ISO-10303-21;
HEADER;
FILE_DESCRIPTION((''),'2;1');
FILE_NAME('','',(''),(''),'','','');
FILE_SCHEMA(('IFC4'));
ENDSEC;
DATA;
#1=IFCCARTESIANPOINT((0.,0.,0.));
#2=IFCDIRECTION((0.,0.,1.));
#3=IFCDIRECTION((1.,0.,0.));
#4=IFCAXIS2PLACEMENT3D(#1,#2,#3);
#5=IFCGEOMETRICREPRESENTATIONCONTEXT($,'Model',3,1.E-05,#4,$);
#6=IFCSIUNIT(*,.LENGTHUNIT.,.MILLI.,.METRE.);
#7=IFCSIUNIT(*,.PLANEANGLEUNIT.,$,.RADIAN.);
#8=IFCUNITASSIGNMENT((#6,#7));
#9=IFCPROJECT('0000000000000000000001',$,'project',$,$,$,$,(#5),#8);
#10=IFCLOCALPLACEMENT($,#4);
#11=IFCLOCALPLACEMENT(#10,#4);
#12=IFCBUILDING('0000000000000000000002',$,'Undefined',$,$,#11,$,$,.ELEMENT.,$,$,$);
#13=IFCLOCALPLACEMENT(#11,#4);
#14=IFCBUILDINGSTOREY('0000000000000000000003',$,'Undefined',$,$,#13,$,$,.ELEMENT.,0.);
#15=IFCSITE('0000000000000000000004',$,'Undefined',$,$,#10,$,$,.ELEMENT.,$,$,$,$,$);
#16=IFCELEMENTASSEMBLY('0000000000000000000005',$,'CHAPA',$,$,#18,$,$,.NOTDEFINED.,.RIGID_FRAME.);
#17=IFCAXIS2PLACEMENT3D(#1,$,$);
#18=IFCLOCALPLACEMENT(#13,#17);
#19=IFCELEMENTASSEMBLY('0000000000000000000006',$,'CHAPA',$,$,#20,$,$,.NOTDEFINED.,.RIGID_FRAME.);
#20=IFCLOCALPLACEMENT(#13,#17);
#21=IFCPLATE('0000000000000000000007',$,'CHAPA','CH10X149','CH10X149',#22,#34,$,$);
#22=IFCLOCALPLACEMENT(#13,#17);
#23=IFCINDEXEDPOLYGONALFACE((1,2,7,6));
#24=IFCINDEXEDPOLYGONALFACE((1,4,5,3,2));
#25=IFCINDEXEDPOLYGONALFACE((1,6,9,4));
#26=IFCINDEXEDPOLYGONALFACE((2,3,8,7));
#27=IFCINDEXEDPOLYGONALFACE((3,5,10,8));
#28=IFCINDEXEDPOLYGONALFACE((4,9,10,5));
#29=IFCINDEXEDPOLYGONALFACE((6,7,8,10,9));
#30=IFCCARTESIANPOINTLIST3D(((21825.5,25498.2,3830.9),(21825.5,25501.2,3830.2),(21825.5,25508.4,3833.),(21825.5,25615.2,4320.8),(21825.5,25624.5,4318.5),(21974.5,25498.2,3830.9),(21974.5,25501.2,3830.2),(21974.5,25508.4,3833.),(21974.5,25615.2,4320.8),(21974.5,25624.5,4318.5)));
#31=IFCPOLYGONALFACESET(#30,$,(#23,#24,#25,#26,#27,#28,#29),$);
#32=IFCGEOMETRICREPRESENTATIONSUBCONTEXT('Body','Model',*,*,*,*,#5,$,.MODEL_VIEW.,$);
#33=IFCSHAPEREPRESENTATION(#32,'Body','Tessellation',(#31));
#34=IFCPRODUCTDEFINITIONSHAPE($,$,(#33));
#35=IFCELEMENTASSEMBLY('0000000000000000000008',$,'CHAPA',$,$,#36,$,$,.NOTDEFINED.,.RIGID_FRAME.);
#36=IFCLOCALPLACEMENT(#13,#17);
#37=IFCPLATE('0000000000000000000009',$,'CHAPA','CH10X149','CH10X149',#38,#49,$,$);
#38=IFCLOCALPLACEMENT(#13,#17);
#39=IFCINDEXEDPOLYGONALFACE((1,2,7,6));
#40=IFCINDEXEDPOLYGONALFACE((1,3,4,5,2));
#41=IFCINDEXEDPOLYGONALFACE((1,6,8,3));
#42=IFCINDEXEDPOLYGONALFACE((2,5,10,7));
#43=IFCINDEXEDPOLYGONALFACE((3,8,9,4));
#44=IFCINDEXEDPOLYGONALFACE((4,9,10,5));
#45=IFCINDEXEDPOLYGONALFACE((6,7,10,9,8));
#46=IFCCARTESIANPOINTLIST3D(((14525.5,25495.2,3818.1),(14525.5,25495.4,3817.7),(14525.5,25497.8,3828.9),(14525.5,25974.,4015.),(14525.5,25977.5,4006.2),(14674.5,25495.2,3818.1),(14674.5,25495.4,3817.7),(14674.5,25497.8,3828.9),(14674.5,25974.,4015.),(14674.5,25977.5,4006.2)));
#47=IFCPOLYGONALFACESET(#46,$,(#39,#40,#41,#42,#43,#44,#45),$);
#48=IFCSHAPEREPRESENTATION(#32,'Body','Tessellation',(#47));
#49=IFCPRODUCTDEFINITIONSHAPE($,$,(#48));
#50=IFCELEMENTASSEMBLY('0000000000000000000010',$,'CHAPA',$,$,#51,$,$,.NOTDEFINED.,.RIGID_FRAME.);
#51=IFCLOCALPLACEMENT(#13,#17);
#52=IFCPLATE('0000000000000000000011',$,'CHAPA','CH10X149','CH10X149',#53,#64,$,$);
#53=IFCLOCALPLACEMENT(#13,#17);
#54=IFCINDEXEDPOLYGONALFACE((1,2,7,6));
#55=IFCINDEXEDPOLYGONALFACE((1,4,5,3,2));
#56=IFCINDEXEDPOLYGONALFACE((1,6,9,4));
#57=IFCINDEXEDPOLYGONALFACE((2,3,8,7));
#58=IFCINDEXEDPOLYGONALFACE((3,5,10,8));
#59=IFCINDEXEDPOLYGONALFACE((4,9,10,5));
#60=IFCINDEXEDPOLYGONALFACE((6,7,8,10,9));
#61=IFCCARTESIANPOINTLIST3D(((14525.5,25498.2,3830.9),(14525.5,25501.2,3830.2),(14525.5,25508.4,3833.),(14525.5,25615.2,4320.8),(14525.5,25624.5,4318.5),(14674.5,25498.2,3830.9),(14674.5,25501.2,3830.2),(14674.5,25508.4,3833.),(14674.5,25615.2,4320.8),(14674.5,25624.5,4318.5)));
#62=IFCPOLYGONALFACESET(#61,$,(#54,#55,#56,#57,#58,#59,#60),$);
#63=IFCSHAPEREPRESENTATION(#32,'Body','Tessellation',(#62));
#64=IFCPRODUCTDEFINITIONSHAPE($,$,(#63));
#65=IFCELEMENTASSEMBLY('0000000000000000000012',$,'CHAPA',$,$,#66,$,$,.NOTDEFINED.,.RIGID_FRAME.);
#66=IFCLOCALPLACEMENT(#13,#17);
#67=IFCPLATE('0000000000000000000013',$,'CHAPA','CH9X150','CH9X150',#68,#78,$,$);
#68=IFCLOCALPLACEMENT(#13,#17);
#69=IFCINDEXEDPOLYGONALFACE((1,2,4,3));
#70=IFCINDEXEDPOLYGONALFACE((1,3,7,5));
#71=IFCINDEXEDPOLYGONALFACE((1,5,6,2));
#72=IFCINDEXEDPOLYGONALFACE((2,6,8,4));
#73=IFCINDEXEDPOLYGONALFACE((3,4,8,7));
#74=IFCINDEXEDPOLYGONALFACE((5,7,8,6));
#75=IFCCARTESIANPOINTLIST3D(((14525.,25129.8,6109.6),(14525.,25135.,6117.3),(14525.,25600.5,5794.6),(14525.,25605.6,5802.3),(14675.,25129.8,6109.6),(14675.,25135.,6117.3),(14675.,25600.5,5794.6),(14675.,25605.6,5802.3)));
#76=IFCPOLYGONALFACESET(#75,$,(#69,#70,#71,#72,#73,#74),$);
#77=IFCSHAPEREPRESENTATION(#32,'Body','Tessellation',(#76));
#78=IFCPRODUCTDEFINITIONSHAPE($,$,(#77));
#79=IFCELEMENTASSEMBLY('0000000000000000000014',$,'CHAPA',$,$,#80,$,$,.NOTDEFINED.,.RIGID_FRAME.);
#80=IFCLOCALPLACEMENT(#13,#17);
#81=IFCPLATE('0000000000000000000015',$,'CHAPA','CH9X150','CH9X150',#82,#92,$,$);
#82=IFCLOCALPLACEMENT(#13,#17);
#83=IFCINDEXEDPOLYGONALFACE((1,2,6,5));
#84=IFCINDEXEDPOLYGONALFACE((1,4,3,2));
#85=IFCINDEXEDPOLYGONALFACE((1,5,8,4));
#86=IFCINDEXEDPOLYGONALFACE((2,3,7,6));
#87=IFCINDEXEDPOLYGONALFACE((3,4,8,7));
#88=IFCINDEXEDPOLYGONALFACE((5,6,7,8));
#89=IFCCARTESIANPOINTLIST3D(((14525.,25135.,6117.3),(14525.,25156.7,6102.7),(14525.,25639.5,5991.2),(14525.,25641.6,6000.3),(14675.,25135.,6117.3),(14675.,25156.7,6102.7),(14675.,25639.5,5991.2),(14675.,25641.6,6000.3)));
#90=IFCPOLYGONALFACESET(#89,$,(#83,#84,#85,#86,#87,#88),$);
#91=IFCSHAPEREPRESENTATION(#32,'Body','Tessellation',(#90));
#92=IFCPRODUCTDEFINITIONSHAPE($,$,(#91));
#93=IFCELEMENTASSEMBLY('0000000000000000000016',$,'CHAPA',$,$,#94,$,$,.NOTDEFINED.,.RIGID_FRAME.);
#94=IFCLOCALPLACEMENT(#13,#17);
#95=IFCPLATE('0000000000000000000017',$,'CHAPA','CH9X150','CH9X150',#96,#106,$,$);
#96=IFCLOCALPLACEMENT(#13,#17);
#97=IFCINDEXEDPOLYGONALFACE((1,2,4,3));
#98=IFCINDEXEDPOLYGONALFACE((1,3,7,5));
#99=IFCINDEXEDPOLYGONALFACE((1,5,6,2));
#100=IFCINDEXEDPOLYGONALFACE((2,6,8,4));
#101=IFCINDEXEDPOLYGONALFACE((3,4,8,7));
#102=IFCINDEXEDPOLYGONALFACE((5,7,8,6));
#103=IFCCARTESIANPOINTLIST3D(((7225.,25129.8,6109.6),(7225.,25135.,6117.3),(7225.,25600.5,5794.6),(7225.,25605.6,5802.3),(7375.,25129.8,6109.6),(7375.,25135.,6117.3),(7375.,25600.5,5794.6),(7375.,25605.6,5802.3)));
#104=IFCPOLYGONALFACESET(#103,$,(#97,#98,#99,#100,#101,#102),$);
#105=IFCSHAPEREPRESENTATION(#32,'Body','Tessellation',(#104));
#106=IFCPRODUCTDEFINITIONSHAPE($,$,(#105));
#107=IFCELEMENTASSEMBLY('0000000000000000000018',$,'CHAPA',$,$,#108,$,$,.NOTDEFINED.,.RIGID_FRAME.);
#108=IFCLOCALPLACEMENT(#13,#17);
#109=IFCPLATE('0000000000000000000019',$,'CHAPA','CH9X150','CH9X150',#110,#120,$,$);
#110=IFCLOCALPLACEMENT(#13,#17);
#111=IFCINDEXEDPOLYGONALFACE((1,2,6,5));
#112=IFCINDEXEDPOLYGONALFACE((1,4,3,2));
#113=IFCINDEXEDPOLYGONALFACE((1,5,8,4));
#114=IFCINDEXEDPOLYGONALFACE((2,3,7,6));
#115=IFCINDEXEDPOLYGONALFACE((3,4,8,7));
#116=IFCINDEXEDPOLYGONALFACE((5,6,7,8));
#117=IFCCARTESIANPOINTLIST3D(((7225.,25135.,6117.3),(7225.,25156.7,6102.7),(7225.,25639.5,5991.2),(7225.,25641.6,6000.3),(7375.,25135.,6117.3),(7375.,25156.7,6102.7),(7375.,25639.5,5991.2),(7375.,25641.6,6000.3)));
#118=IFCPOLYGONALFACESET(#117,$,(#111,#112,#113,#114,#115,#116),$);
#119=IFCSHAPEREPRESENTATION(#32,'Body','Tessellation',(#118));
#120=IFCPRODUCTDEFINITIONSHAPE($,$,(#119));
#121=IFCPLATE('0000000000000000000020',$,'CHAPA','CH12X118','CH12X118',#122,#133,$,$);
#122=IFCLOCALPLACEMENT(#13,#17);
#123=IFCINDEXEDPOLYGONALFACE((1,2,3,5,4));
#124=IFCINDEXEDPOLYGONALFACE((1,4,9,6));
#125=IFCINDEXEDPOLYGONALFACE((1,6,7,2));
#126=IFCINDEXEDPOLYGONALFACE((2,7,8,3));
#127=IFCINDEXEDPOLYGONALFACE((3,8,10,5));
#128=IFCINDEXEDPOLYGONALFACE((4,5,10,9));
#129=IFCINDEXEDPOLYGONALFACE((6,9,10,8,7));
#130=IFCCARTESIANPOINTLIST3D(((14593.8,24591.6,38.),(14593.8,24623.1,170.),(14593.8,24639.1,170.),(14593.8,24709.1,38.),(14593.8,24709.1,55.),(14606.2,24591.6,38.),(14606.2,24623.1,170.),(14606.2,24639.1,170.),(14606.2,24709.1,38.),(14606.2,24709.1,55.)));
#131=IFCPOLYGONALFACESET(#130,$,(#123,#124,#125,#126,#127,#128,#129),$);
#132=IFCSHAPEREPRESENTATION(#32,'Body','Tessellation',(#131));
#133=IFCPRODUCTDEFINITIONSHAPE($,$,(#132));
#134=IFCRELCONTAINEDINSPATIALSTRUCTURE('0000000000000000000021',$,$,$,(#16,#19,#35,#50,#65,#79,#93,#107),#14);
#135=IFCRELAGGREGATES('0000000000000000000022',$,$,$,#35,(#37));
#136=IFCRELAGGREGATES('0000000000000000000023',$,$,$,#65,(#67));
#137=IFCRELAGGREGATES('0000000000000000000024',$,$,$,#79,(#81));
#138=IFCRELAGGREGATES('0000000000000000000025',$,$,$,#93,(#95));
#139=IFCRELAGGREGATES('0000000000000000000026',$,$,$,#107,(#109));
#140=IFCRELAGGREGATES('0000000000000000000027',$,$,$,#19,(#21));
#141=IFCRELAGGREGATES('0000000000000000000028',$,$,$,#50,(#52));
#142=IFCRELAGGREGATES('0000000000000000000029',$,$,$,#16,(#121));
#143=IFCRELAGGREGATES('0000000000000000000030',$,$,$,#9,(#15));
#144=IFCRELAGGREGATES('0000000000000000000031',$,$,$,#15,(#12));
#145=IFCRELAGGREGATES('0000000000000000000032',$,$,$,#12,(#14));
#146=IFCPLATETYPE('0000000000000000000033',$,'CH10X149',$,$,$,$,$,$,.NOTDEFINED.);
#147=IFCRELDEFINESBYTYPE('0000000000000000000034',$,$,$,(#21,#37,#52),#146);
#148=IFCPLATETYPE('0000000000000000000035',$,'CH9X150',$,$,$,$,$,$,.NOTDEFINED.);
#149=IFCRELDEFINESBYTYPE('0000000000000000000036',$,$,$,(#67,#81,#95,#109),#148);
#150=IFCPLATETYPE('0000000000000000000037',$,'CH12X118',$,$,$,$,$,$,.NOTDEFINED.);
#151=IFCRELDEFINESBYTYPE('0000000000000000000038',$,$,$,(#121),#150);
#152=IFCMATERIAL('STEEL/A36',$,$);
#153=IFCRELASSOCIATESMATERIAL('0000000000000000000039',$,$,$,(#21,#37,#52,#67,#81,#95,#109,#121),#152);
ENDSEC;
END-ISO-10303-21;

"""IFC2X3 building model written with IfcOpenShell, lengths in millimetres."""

from ifc_helpers import new_model, si_unit, frame, origin_with_axes, place, context, subcontext, project, spatial, polyline, outline, extrude, clip, halfspace, material, type_object, element, aggregate, save


model = new_model("IFC2X3")

# Units and contexts
model_context = context("Model", 3, precision=1e-05, world=origin_with_axes())
body_context = subcontext(model_context, "Body", "Model", "MODEL_VIEW")
ifc_project = project(units=[si_unit("LENGTHUNIT", "METRE", prefix="MILLI"), si_unit("PLANEANGLEUNIT", "RADIAN")], contexts=[model_context])

# Site, building, storey
site_placement = place(None, origin_with_axes())
site = spatial("IfcSite", under=ifc_project, at=site_placement, Name="Undefined", CompositionType="ELEMENT")
building_placement = place(site_placement, origin_with_axes())
building = spatial("IfcBuilding", under=site, at=building_placement, Name="Undefined", CompositionType="ELEMENT")
storey_placement = place(building_placement, origin_with_axes())
storey = spatial("IfcBuildingStorey", under=building, at=storey_placement, Name="Undefined", CompositionType="ELEMENT", Elevation=0.0)

# Element assembly
ifc_material_1 = material(Name="STEEL/A36")
assembly_1_placement = place(storey_placement, origin_with_axes())
assembly_1 = element("IfcElementAssembly", 1, at=assembly_1_placement, inside=storey, Name="CHAPA", AssemblyPlace="NOTDEFINED", PredefinedType="RIGID_FRAME")

# Element assemblies, plates
plate_type_1 = type_object("IfcPlateType", Name="CH10X149", PredefinedType="NOTDEFINED")
assembly_2_placement = place(storey_placement, origin_with_axes())
assembly_2 = element("IfcElementAssembly", 2, at=assembly_2_placement, inside=storey, Name="CHAPA", AssemblyPlace="NOTDEFINED", PredefinedType="RIGID_FRAME")
plate_1_placement = place(assembly_2_placement, frame((21825.5, 25619.9, 4319.6), z_axis=(0.0, 0.972612, -0.232434), x_axis=(1.0, 0.000007, 0.000031)))
plate_1 = element("IfcPlate", 3, at=plate_1_placement, type_object=plate_type_1, material=ifc_material_1, Name="CHAPA", Description="CH10X149", ObjectType="CH10X149", context=body_context, shape_type="Clipping", body=[
    clip(extrude(outline(polyline([(0.0, 0.0), (70.9, 0.0), (149.0, 0.0), (149.0, 503.6), (0.0, 503.6), (0.0, 0.0)])), frame((0.0, 0.0, -4.8), z_axis=(0.0, 0.0, 1.0), x_axis=(1.0, 0.0, 0.0)), (0.0, 0.0, 1.0), 9.5), halfspace(frame((70.9, 499.2, 4.7), z_axis=(-0.000026, 0.821245, 0.570575), x_axis=(-1.0, -0.000032, 0.0)), False)),
])
assembly_3_placement = place(storey_placement, origin_with_axes())
assembly_3 = element("IfcElementAssembly", 4, at=assembly_3_placement, inside=storey, Name="CHAPA", AssemblyPlace="NOTDEFINED", PredefinedType="RIGID_FRAME")
plate_2_placement = place(assembly_3_placement, frame((14525.5, 25975.7, 4010.6), z_axis=(0.0, 0.364063, -0.931374), x_axis=(1.0, 0.0, 0.0)))
plate_2 = element("IfcPlate", 5, at=plate_2_placement, type_object=plate_type_1, material=ifc_material_1, Name="CHAPA", Description="CH10X149", ObjectType="CH10X149", context=body_context, shape_type="Clipping", body=[
    clip(extrude(outline(polyline([(0.0, 0.0), (149.0, 0.0), (149.0, 517.6), (0.0, 517.6), (0.0, 0.0)])), frame((0.0, 0.0, -4.8), z_axis=(0.0, 0.0, 1.0), x_axis=(1.0, 0.0, 0.0)), (0.0, 0.0, 1.0), 9.5), halfspace(frame((149.0, 517.9, 4.7), z_axis=(0.0, 0.821204, -0.570634), x_axis=(-1.0, 0.0, 0.0)), False)),
])
aggregate(assembly_3, [plate_2])
assembly_4_placement = place(storey_placement, origin_with_axes())
assembly_4 = element("IfcElementAssembly", 6, at=assembly_4_placement, inside=storey, Name="CHAPA", AssemblyPlace="NOTDEFINED", PredefinedType="RIGID_FRAME")
plate_3_placement = place(assembly_4_placement, frame((14525.5, 25619.9, 4319.6), z_axis=(0.0, 0.972612, -0.232434), x_axis=(1.0, 0.000007, 0.000031)))
plate_3 = element("IfcPlate", 7, at=plate_3_placement, type_object=plate_type_1, material=ifc_material_1, Name="CHAPA", Description="CH10X149", ObjectType="CH10X149", context=body_context, shape_type="Clipping", body=[
    clip(extrude(outline(polyline([(0.0, 0.0), (70.9, 0.0), (149.0, 0.0), (149.0, 503.6), (0.0, 503.6), (0.0, 0.0)])), frame((0.0, 0.0, -4.8), z_axis=(0.0, 0.0, 1.0), x_axis=(1.0, 0.0, 0.0)), (0.0, 0.0, 1.0), 9.5), halfspace(frame((70.9, 499.2, 4.7), z_axis=(-0.000026, 0.821245, 0.570575), x_axis=(-1.0, -0.000032, 0.0)), False)),
])
assembly_5_placement = place(storey_placement, origin_with_axes())
assembly_5 = element("IfcElementAssembly", 8, at=assembly_5_placement, inside=storey, Name="CHAPA", AssemblyPlace="NOTDEFINED", PredefinedType="RIGID_FRAME")
plate_type_2 = type_object("IfcPlateType", Name="CH9X150", PredefinedType="NOTDEFINED")
plate_4_placement = place(assembly_5_placement, frame((14675.0, 25132.4, 6113.5), z_axis=(0.0, -0.55615, -0.831082), x_axis=(-1.0, 0.0, 0.0)))
plate_4 = element("IfcPlate", 9, at=plate_4_placement, type_object=plate_type_2, material=ifc_material_1, Name="CHAPA", Description="CH9X150", ObjectType="CH9X150", context=body_context, shape_type="SweptSolid", body=[
    extrude(outline(polyline([(0.0, 0.0), (150.0, 0.0), (150.0, 566.3), (0.0, 566.3), (0.0, 0.0)])), frame((0.0, 0.0, -4.7), z_axis=(0.0, 0.0, 1.0), x_axis=(1.0, 0.0, 0.0)), (0.0, 0.0, 1.0), 9.3),
])
aggregate(assembly_5, [plate_4])
assembly_6_placement = place(storey_placement, origin_with_axes())
assembly_6 = element("IfcElementAssembly", 10, at=assembly_6_placement, inside=storey, Name="CHAPA", AssemblyPlace="NOTDEFINED", PredefinedType="RIGID_FRAME")
plate_5_placement = place(assembly_6_placement, frame((14675.0, 25640.6, 5995.7), z_axis=(0.0, -0.225124, -0.97433), x_axis=(0.0, -0.97433, 0.225124)))
plate_5 = element("IfcPlate", 11, at=plate_5_placement, type_object=plate_type_2, material=ifc_material_1, Name="CHAPA", Description="CH9X150", ObjectType="CH9X150", context=body_context, shape_type="Clipping", body=[
    clip(extrude(outline(polyline([(0.0, 0.0), (520.0, 0.0), (520.0, 150.0), (0.0, 150.0), (0.0, 0.0)])), frame((0.0, 0.0, -4.7), z_axis=(0.0, 0.0, 1.0), x_axis=(1.0, 0.0, 0.0)), (0.0, 0.0, 1.0), 9.3), halfspace(frame((520.0, -500.0, -4.7), z_axis=(0.354778, 0.0, 0.934951), x_axis=(-0.934951, 0.0, 0.354778)), False)),
])
aggregate(assembly_6, [plate_5])
assembly_7_placement = place(storey_placement, origin_with_axes())
assembly_7 = element("IfcElementAssembly", 12, at=assembly_7_placement, inside=storey, Name="CHAPA", AssemblyPlace="NOTDEFINED", PredefinedType="RIGID_FRAME")
plate_6_placement = place(assembly_7_placement, frame((7375.0, 25132.4, 6113.5), z_axis=(0.0, -0.55615, -0.831082), x_axis=(-1.0, 0.0, 0.0)))
plate_6 = element("IfcPlate", 13, at=plate_6_placement, type_object=plate_type_2, material=ifc_material_1, Name="CHAPA", Description="CH9X150", ObjectType="CH9X150", context=body_context, shape_type="SweptSolid", body=[
    extrude(outline(polyline([(0.0, 0.0), (150.0, 0.0), (150.0, 566.3), (0.0, 566.3), (0.0, 0.0)])), frame((0.0, 0.0, -4.7), z_axis=(0.0, 0.0, 1.0), x_axis=(1.0, 0.0, 0.0)), (0.0, 0.0, 1.0), 9.3),
])
aggregate(assembly_7, [plate_6])
assembly_8_placement = place(storey_placement, origin_with_axes())
assembly_8 = element("IfcElementAssembly", 14, at=assembly_8_placement, inside=storey, Name="CHAPA", AssemblyPlace="NOTDEFINED", PredefinedType="RIGID_FRAME")
plate_7_placement = place(assembly_8_placement, frame((7375.0, 25640.6, 5995.7), z_axis=(0.0, -0.225124, -0.97433), x_axis=(0.0, -0.97433, 0.225124)))
plate_7 = element("IfcPlate", 15, at=plate_7_placement, type_object=plate_type_2, material=ifc_material_1, Name="CHAPA", Description="CH9X150", ObjectType="CH9X150", context=body_context, shape_type="Clipping", body=[
    clip(extrude(outline(polyline([(0.0, 0.0), (520.0, 0.0), (520.0, 150.0), (0.0, 150.0), (0.0, 0.0)])), frame((0.0, 0.0, -4.7), z_axis=(0.0, 0.0, 1.0), x_axis=(1.0, 0.0, 0.0)), (0.0, 0.0, 1.0), 9.3), halfspace(frame((520.0, -500.0, -4.7), z_axis=(0.354778, 0.0, 0.934951), x_axis=(-0.934951, 0.0, 0.354778)), False)),
])
aggregate(assembly_8, [plate_7])

# Plate
plate_type_3 = type_object("IfcPlateType", Name="CH12X118", PredefinedType="NOTDEFINED")
plate_8_placement = place(assembly_1_placement, frame((14600.0, 24709.1, 38.0), z_axis=(-1.0, 0.0, 0.0), x_axis=(0.0, -1.0, 0.0)))
plate_8 = element("IfcPlate", 16, at=plate_8_placement, type_object=plate_type_3, material=ifc_material_1, Name="CHAPA", Description="CH12X118", ObjectType="CH12X118", context=body_context, shape_type="SweptSolid", body=[
    extrude(outline(polyline([(0.0, 0.0), (117.5, 0.0), (85.9, 132.0), (70.0, 132.0), (0.0, 17.0), (0.0, 0.0)])), frame((0.0, 0.0, -6.2), z_axis=(0.0, 0.0, 1.0), x_axis=(1.0, 0.0, 0.0)), (0.0, 0.0, 1.0), 12.5),
])

aggregate(assembly_2, [plate_1])
aggregate(assembly_4, [plate_3])
aggregate(assembly_1, [plate_8])

save(model, "model.ifc")
